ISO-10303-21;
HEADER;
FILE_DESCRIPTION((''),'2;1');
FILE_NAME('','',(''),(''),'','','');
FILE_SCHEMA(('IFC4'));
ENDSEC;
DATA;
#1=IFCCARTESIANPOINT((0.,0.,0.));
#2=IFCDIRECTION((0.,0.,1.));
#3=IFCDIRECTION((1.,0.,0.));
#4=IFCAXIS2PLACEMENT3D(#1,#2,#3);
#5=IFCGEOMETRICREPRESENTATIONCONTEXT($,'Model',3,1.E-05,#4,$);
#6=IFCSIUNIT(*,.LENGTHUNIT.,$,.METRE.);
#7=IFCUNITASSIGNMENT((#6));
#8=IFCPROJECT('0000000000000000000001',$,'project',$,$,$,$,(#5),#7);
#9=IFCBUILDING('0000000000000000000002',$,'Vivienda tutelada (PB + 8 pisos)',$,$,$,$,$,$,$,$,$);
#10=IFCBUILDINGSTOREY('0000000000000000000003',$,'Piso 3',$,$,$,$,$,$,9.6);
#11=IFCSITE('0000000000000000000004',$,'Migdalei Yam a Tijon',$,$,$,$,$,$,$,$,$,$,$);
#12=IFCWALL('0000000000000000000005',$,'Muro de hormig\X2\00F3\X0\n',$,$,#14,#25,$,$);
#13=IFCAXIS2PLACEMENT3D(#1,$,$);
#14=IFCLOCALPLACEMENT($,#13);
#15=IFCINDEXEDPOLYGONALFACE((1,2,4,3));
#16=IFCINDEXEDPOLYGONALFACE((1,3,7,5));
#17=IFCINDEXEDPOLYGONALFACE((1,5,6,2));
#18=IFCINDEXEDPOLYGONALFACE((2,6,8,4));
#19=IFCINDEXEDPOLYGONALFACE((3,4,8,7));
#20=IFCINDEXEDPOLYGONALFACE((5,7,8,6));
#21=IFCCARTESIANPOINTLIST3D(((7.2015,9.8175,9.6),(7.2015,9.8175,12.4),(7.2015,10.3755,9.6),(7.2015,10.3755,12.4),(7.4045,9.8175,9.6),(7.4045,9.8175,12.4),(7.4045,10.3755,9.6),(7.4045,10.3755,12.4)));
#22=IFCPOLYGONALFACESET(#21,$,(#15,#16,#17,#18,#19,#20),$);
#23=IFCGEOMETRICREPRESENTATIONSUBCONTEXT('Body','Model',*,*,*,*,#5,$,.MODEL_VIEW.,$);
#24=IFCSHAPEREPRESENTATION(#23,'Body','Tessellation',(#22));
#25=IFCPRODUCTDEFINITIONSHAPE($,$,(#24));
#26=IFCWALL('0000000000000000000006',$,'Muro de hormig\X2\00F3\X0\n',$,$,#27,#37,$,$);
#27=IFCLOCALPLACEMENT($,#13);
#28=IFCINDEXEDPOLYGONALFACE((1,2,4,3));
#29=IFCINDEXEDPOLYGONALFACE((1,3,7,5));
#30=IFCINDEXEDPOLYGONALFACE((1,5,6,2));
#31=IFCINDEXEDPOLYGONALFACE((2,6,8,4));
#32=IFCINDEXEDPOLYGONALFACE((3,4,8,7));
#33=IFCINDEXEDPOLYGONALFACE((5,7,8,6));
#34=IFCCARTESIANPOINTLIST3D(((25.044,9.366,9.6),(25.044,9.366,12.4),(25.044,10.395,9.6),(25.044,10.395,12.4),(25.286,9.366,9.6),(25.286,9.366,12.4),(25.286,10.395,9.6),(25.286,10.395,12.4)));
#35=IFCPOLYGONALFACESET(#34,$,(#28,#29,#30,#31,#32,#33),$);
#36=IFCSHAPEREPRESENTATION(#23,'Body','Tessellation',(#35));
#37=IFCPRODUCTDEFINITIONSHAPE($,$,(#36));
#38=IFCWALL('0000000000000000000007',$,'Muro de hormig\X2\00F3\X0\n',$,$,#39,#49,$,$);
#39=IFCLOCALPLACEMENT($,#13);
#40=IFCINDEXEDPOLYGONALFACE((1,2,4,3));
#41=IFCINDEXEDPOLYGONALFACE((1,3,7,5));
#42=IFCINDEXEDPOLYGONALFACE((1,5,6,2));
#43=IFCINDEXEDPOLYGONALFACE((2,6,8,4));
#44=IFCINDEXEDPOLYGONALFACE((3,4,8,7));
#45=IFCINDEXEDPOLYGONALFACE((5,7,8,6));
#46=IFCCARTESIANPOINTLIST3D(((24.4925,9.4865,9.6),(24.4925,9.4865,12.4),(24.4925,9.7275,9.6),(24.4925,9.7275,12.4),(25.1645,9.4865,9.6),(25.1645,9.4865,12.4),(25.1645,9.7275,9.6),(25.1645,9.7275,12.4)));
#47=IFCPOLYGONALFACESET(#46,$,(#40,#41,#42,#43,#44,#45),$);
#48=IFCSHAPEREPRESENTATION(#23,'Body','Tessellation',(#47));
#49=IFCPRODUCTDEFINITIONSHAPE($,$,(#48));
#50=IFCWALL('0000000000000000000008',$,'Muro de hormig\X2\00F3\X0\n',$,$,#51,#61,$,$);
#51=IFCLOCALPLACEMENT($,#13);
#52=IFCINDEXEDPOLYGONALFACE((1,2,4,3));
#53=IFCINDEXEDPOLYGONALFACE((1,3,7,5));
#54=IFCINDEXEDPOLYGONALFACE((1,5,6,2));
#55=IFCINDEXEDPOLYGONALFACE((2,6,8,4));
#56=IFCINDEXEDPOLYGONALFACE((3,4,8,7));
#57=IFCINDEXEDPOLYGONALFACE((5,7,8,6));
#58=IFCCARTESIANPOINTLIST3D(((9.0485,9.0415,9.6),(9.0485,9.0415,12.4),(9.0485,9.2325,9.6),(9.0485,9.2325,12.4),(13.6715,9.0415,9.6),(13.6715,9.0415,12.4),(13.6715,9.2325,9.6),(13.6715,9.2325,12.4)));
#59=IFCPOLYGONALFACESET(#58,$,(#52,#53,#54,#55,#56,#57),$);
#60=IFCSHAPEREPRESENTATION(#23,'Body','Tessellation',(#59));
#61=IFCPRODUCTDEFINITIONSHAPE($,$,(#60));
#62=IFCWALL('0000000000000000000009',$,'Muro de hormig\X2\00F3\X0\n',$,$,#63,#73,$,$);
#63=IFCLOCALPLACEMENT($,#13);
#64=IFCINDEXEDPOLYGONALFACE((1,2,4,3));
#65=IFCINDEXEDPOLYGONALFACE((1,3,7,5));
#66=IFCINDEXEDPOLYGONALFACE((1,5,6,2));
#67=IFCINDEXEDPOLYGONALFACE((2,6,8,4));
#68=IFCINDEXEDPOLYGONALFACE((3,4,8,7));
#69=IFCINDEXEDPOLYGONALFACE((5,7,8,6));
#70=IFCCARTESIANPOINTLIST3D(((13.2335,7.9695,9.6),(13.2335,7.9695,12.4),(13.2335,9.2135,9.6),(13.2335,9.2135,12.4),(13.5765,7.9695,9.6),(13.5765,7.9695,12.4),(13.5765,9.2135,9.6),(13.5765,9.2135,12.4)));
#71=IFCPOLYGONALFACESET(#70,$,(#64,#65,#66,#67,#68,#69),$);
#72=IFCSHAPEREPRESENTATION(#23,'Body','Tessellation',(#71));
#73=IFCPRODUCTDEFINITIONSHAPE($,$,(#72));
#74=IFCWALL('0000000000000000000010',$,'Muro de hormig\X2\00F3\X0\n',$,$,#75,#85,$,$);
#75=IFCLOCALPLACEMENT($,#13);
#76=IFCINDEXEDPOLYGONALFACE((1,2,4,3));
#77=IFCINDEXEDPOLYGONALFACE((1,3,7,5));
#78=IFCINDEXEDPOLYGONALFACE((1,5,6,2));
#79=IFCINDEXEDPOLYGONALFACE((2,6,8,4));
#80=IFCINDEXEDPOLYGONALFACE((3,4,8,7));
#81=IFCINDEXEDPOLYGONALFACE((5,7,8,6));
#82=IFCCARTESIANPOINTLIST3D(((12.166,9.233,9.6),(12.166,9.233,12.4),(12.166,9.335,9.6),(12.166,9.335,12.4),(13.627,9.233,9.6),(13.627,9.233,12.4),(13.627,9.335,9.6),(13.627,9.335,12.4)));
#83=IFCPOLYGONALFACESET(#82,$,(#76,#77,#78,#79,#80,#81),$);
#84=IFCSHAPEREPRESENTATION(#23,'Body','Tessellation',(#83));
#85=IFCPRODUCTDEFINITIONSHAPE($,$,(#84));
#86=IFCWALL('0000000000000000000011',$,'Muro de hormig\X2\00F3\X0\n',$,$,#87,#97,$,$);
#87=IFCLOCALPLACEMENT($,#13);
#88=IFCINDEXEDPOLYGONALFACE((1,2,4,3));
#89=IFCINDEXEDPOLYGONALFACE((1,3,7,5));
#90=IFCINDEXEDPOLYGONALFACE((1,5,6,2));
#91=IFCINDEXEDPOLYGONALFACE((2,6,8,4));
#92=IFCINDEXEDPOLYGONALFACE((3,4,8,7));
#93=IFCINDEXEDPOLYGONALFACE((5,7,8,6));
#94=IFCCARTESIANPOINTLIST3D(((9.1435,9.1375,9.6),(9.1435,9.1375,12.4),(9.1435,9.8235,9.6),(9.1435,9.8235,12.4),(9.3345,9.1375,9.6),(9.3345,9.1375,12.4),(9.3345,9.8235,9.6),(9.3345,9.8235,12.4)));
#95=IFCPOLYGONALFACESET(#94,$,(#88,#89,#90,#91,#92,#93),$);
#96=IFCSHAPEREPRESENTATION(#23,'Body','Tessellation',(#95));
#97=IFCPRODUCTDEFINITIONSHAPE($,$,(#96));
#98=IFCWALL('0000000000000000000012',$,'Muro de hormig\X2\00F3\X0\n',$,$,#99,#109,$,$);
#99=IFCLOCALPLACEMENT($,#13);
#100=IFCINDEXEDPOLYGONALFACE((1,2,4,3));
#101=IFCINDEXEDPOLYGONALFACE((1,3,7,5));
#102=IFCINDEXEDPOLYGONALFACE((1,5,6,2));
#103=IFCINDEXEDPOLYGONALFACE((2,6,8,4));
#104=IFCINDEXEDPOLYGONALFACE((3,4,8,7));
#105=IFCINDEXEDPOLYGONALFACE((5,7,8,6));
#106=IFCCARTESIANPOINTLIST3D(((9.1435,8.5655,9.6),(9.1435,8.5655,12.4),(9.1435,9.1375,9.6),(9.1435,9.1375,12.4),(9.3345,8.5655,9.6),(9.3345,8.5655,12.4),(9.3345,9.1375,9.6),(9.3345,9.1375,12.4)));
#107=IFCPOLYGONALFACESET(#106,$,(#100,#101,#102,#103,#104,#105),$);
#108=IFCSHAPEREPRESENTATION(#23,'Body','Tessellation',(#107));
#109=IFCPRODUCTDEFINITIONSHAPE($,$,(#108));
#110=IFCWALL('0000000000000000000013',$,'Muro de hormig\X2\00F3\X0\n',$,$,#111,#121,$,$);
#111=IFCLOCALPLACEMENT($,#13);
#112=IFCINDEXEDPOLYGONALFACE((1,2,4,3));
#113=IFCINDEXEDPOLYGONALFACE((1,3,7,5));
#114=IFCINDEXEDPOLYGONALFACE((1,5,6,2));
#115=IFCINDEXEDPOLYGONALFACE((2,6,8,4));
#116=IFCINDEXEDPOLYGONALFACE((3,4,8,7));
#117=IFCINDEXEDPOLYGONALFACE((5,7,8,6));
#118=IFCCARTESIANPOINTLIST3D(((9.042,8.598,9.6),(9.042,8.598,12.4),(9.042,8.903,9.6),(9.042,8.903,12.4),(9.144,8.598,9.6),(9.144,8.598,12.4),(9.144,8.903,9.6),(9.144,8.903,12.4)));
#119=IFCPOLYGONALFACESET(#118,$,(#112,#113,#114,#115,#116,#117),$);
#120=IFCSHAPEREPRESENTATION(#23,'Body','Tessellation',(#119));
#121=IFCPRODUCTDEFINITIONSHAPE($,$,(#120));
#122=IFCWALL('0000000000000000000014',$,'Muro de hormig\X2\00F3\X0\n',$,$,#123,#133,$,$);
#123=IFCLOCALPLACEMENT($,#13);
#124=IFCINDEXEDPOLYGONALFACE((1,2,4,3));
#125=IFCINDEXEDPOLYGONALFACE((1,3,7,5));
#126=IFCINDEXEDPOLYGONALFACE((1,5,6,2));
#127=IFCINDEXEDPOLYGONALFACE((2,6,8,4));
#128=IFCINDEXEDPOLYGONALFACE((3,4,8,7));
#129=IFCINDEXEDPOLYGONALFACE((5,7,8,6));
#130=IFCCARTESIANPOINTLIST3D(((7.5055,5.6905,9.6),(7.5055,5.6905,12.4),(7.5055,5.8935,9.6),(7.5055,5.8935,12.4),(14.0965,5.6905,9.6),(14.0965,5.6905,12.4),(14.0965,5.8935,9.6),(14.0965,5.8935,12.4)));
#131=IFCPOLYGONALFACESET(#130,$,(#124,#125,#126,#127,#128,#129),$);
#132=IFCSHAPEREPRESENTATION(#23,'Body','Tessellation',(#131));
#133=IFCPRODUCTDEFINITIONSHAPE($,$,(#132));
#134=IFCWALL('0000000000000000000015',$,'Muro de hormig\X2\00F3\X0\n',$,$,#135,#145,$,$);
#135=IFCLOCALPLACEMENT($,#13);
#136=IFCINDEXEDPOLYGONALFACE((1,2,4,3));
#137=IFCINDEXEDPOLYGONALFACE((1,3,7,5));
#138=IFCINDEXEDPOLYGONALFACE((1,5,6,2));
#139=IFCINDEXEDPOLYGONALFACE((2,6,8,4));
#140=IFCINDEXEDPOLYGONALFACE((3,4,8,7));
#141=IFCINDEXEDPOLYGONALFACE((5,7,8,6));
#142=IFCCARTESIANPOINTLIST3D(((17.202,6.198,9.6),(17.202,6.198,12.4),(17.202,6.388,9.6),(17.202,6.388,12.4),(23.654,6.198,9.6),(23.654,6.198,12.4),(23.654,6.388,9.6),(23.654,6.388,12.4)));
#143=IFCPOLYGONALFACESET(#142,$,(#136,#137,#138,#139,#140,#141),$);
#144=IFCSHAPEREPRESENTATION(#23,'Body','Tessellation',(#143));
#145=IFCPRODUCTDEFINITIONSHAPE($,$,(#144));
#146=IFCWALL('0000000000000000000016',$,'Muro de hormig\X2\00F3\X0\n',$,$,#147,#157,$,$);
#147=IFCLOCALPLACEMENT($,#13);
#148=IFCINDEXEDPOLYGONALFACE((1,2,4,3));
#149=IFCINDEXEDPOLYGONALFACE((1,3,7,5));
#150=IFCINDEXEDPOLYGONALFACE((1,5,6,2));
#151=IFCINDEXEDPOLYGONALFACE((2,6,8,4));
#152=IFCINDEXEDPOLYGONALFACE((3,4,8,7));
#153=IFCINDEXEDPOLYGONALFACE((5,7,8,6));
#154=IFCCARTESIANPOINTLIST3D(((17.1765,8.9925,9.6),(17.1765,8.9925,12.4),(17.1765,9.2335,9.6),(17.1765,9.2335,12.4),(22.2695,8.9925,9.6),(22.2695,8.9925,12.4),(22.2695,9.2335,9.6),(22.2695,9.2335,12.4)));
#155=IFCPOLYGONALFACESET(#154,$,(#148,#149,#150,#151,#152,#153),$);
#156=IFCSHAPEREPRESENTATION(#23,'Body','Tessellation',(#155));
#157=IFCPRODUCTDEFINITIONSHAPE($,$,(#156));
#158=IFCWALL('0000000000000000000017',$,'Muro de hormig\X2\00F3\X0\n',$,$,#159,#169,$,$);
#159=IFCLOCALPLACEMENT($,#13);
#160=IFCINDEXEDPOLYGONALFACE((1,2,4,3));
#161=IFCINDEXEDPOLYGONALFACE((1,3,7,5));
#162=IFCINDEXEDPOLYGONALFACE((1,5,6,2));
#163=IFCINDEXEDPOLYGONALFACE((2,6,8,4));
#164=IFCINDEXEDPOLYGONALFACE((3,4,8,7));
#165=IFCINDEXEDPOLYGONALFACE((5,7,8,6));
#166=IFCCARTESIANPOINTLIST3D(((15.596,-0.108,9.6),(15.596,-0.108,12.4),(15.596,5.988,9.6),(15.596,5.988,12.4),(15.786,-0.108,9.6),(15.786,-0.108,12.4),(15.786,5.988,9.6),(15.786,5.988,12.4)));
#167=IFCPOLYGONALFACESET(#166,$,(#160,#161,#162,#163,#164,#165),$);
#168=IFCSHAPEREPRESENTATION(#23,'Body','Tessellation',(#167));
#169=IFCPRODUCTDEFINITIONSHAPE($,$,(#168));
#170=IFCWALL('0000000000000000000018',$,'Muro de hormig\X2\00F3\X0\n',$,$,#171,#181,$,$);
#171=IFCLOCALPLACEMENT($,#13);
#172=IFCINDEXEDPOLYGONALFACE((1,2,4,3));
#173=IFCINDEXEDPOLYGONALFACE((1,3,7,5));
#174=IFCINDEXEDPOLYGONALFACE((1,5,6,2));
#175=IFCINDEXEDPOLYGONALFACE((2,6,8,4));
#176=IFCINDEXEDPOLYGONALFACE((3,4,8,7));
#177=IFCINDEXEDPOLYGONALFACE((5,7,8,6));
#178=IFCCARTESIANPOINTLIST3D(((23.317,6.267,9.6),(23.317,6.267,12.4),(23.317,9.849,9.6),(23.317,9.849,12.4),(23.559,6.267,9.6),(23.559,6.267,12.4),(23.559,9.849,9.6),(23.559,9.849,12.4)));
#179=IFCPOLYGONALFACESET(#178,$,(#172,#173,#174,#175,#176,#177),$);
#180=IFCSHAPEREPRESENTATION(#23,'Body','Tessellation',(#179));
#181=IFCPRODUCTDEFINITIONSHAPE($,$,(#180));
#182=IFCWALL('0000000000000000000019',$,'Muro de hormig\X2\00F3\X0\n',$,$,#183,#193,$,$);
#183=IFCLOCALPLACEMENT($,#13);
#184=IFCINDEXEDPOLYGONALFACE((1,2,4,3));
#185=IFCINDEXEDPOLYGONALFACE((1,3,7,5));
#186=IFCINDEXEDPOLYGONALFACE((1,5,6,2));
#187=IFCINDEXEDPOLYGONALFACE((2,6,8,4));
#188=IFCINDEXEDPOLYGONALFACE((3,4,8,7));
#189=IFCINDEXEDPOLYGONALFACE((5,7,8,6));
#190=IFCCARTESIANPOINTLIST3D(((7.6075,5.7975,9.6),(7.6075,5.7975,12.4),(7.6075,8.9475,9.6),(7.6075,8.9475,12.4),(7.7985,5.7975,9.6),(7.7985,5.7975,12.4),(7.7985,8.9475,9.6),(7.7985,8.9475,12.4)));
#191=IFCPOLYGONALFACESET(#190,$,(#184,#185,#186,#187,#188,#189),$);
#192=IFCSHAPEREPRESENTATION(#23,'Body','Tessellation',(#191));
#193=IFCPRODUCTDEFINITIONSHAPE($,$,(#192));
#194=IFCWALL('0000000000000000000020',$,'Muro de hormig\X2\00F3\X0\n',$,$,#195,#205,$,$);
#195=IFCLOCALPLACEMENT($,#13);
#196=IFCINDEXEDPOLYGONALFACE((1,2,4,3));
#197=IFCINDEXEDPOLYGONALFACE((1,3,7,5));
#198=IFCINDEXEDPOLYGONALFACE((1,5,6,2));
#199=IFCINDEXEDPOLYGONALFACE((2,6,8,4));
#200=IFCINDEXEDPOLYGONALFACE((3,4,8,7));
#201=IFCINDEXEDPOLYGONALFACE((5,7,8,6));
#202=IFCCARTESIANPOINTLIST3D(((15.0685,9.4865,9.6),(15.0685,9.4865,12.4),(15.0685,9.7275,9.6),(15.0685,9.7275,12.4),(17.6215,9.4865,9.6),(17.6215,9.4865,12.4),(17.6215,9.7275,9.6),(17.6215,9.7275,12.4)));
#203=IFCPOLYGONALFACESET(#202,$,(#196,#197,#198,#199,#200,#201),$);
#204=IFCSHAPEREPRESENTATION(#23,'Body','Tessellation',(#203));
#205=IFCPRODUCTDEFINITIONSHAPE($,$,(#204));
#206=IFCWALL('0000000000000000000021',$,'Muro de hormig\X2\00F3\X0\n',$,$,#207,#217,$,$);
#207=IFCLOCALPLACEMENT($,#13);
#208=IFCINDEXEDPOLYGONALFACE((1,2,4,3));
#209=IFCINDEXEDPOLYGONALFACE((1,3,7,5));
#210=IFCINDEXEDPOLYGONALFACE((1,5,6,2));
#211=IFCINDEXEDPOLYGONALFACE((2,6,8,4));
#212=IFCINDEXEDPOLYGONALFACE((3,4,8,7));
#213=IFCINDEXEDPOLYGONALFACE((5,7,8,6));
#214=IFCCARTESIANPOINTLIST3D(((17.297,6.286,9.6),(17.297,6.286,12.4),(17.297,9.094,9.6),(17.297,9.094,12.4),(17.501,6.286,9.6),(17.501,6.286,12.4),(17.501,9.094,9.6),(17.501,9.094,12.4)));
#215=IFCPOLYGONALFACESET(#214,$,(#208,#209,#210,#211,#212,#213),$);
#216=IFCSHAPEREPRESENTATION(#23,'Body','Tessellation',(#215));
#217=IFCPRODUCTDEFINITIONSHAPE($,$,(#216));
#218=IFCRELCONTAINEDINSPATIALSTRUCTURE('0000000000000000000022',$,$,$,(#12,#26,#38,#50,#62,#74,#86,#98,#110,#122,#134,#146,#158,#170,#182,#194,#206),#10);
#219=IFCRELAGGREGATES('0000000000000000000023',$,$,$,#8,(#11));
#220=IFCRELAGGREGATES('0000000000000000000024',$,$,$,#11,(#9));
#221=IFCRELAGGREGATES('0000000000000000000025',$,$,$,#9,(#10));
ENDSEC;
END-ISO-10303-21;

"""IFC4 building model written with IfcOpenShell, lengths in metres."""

from ifc_helpers import new_model, si_unit, frame, origin_with_axes, context, subcontext, project, spatial, line, indexed_curve, outline, extrude, element, save


model = new_model("IFC4")

# Units and contexts
model_context = context("Model", 3, precision=1e-05, world=origin_with_axes())
body_context = subcontext(model_context, "Body", "Model", "MODEL_VIEW")
ifc_project = project(units=[si_unit("LENGTHUNIT", "METRE")], contexts=[model_context])

# Site, building, storey
site = spatial("IfcSite", under=ifc_project, Name="Migdalei Yam a Tijon")
building = spatial("IfcBuilding", under=site, Name="Vivienda tutelada (PB + 8 pisos)")
storey = spatial("IfcBuildingStorey", under=building, Name="Piso 3", Elevation=9.6)

# Walls
element("IfcWall", 1, inside=storey, Name="Muro de hormigón", context=body_context, shape_type="SweptSolid", body=[
    extrude(outline(indexed_curve([(0.0, 0.0), (0.203, 0.0), (0.203, 0.558), (0.0, 0.558)], segments=[line(1, 2, 3, 4, 1)])), frame((7.2015, 9.8175, 9.6), z_axis=(0.0, 0.0, 1.0), x_axis=(1.0, 0.0, 0.0)), (0.0, 0.0, 1.0), 2.8),
])
element("IfcWall", 2, inside=storey, Name="Muro de hormigón", context=body_context, shape_type="SweptSolid", body=[
    extrude(outline(indexed_curve([(0.0, 0.0), (0.242, 0.0), (0.242, 1.029), (0.0, 1.029)], segments=[line(1, 2, 3, 4, 1)])), frame((25.044, 9.366, 9.6), z_axis=(0.0, 0.0, 1.0), x_axis=(1.0, 0.0, 0.0)), (0.0, 0.0, 1.0), 2.8),
])
element("IfcWall", 3, inside=storey, Name="Muro de hormigón", context=body_context, shape_type="SweptSolid", body=[
    extrude(outline(indexed_curve([(0.0, 0.0), (0.672, 0.0), (0.672, 0.241), (0.0, 0.241)], segments=[line(1, 2, 3, 4, 1)])), frame((24.4925, 9.4865, 9.6), z_axis=(0.0, 0.0, 1.0), x_axis=(1.0, 0.0, 0.0)), (0.0, 0.0, 1.0), 2.8),
])
element("IfcWall", 4, inside=storey, Name="Muro de hormigón", context=body_context, shape_type="SweptSolid", body=[
    extrude(outline(indexed_curve([(0.0, 0.0), (4.623, 0.0), (4.623, 0.191), (0.0, 0.191)], segments=[line(1, 2, 3, 4, 1)])), frame((9.0485, 9.0415, 9.6), z_axis=(0.0, 0.0, 1.0), x_axis=(1.0, 0.0, 0.0)), (0.0, 0.0, 1.0), 2.8),
])
element("IfcWall", 5, inside=storey, Name="Muro de hormigón", context=body_context, shape_type="SweptSolid", body=[
    extrude(outline(indexed_curve([(0.0, 0.0), (0.343, 0.0), (0.343, 1.244), (0.0, 1.244)], segments=[line(1, 2, 3, 4, 1)])), frame((13.2335, 7.9695, 9.6), z_axis=(0.0, 0.0, 1.0), x_axis=(1.0, 0.0, 0.0)), (0.0, 0.0, 1.0), 2.8),
])
element("IfcWall", 6, inside=storey, Name="Muro de hormigón", context=body_context, shape_type="SweptSolid", body=[
    extrude(outline(indexed_curve([(0.0, 0.0), (1.461, 0.0), (1.461, 0.102), (0.0, 0.102)], segments=[line(1, 2, 3, 4, 1)])), frame((12.166, 9.233, 9.6), z_axis=(0.0, 0.0, 1.0), x_axis=(1.0, 0.0, 0.0)), (0.0, 0.0, 1.0), 2.8),
])
element("IfcWall", 7, inside=storey, Name="Muro de hormigón", context=body_context, shape_type="SweptSolid", body=[
    extrude(outline(indexed_curve([(0.0, 0.0), (0.191, 0.0), (0.191, 0.686), (0.0, 0.686)], segments=[line(1, 2, 3, 4, 1)])), frame((9.1435, 9.1375, 9.6), z_axis=(0.0, 0.0, 1.0), x_axis=(1.0, 0.0, 0.0)), (0.0, 0.0, 1.0), 2.8),
])
element("IfcWall", 8, inside=storey, Name="Muro de hormigón", context=body_context, shape_type="SweptSolid", body=[
    extrude(outline(indexed_curve([(0.0, 0.0), (0.191, 0.0), (0.191, 0.572), (0.0, 0.572)], segments=[line(1, 2, 3, 4, 1)])), frame((9.1435, 8.5655, 9.6), z_axis=(0.0, 0.0, 1.0), x_axis=(1.0, 0.0, 0.0)), (0.0, 0.0, 1.0), 2.8),
])
element("IfcWall", 9, inside=storey, Name="Muro de hormigón", context=body_context, shape_type="SweptSolid", body=[
    extrude(outline(indexed_curve([(0.0, 0.0), (0.102, 0.0), (0.102, 0.305), (0.0, 0.305)], segments=[line(1, 2, 3, 4, 1)])), frame((9.042, 8.598, 9.6), z_axis=(0.0, 0.0, 1.0), x_axis=(1.0, 0.0, 0.0)), (0.0, 0.0, 1.0), 2.8),
])
element("IfcWall", 10, inside=storey, Name="Muro de hormigón", context=body_context, shape_type="SweptSolid", body=[
    extrude(outline(indexed_curve([(0.0, 0.0), (6.591, 0.0), (6.591, 0.203), (0.0, 0.203)], segments=[line(1, 2, 3, 4, 1)])), frame((7.5055, 5.6905, 9.6), z_axis=(0.0, 0.0, 1.0), x_axis=(1.0, 0.0, 0.0)), (0.0, 0.0, 1.0), 2.8),
])
element("IfcWall", 11, inside=storey, Name="Muro de hormigón", context=body_context, shape_type="SweptSolid", body=[
    extrude(outline(indexed_curve([(0.0, 0.0), (6.452, 0.0), (6.452, 0.19), (0.0, 0.19)], segments=[line(1, 2, 3, 4, 1)])), frame((17.202, 6.198, 9.6), z_axis=(0.0, 0.0, 1.0), x_axis=(1.0, 0.0, 0.0)), (0.0, 0.0, 1.0), 2.8),
])
element("IfcWall", 12, inside=storey, Name="Muro de hormigón", context=body_context, shape_type="SweptSolid", body=[
    extrude(outline(indexed_curve([(0.0, 0.0), (5.093, 0.0), (5.093, 0.241), (0.0, 0.241)], segments=[line(1, 2, 3, 4, 1)])), frame((17.1765, 8.9925, 9.6), z_axis=(0.0, 0.0, 1.0), x_axis=(1.0, 0.0, 0.0)), (0.0, 0.0, 1.0), 2.8),
])
element("IfcWall", 13, inside=storey, Name="Muro de hormigón", context=body_context, shape_type="SweptSolid", body=[
    extrude(outline(indexed_curve([(0.0, 0.0), (0.19, 0.0), (0.19, 6.096), (0.0, 6.096)], segments=[line(1, 2, 3, 4, 1)])), frame((15.596, -0.108, 9.6), z_axis=(0.0, 0.0, 1.0), x_axis=(1.0, 0.0, 0.0)), (0.0, 0.0, 1.0), 2.8),
])
element("IfcWall", 14, inside=storey, Name="Muro de hormigón", context=body_context, shape_type="SweptSolid", body=[
    extrude(outline(indexed_curve([(0.0, 0.0), (0.242, 0.0), (0.242, 3.582), (0.0, 3.582)], segments=[line(1, 2, 3, 4, 1)])), frame((23.317, 6.267, 9.6), z_axis=(0.0, 0.0, 1.0), x_axis=(1.0, 0.0, 0.0)), (0.0, 0.0, 1.0), 2.8),
])
element("IfcWall", 15, inside=storey, Name="Muro de hormigón", context=body_context, shape_type="SweptSolid", body=[
    extrude(outline(indexed_curve([(0.0, 0.0), (0.191, 0.0), (0.191, 3.15), (0.0, 3.15)], segments=[line(1, 2, 3, 4, 1)])), frame((7.6075, 5.7975, 9.6), z_axis=(0.0, 0.0, 1.0), x_axis=(1.0, 0.0, 0.0)), (0.0, 0.0, 1.0), 2.8),
])
element("IfcWall", 16, inside=storey, Name="Muro de hormigón", context=body_context, shape_type="SweptSolid", body=[
    extrude(outline(indexed_curve([(0.0, 0.0), (2.553, 0.0), (2.553, 0.241), (0.0, 0.241)], segments=[line(1, 2, 3, 4, 1)])), frame((15.0685, 9.4865, 9.6), z_axis=(0.0, 0.0, 1.0), x_axis=(1.0, 0.0, 0.0)), (0.0, 0.0, 1.0), 2.8),
])
element("IfcWall", 17, inside=storey, Name="Muro de hormigón", context=body_context, shape_type="SweptSolid", body=[
    extrude(outline(indexed_curve([(0.0, 0.0), (0.204, 0.0), (0.204, 2.808), (0.0, 2.808)], segments=[line(1, 2, 3, 4, 1)])), frame((17.297, 6.286, 9.6), z_axis=(0.0, 0.0, 1.0), x_axis=(1.0, 0.0, 0.0)), (0.0, 0.0, 1.0), 2.8),
])

save(model, "model.ifc")
